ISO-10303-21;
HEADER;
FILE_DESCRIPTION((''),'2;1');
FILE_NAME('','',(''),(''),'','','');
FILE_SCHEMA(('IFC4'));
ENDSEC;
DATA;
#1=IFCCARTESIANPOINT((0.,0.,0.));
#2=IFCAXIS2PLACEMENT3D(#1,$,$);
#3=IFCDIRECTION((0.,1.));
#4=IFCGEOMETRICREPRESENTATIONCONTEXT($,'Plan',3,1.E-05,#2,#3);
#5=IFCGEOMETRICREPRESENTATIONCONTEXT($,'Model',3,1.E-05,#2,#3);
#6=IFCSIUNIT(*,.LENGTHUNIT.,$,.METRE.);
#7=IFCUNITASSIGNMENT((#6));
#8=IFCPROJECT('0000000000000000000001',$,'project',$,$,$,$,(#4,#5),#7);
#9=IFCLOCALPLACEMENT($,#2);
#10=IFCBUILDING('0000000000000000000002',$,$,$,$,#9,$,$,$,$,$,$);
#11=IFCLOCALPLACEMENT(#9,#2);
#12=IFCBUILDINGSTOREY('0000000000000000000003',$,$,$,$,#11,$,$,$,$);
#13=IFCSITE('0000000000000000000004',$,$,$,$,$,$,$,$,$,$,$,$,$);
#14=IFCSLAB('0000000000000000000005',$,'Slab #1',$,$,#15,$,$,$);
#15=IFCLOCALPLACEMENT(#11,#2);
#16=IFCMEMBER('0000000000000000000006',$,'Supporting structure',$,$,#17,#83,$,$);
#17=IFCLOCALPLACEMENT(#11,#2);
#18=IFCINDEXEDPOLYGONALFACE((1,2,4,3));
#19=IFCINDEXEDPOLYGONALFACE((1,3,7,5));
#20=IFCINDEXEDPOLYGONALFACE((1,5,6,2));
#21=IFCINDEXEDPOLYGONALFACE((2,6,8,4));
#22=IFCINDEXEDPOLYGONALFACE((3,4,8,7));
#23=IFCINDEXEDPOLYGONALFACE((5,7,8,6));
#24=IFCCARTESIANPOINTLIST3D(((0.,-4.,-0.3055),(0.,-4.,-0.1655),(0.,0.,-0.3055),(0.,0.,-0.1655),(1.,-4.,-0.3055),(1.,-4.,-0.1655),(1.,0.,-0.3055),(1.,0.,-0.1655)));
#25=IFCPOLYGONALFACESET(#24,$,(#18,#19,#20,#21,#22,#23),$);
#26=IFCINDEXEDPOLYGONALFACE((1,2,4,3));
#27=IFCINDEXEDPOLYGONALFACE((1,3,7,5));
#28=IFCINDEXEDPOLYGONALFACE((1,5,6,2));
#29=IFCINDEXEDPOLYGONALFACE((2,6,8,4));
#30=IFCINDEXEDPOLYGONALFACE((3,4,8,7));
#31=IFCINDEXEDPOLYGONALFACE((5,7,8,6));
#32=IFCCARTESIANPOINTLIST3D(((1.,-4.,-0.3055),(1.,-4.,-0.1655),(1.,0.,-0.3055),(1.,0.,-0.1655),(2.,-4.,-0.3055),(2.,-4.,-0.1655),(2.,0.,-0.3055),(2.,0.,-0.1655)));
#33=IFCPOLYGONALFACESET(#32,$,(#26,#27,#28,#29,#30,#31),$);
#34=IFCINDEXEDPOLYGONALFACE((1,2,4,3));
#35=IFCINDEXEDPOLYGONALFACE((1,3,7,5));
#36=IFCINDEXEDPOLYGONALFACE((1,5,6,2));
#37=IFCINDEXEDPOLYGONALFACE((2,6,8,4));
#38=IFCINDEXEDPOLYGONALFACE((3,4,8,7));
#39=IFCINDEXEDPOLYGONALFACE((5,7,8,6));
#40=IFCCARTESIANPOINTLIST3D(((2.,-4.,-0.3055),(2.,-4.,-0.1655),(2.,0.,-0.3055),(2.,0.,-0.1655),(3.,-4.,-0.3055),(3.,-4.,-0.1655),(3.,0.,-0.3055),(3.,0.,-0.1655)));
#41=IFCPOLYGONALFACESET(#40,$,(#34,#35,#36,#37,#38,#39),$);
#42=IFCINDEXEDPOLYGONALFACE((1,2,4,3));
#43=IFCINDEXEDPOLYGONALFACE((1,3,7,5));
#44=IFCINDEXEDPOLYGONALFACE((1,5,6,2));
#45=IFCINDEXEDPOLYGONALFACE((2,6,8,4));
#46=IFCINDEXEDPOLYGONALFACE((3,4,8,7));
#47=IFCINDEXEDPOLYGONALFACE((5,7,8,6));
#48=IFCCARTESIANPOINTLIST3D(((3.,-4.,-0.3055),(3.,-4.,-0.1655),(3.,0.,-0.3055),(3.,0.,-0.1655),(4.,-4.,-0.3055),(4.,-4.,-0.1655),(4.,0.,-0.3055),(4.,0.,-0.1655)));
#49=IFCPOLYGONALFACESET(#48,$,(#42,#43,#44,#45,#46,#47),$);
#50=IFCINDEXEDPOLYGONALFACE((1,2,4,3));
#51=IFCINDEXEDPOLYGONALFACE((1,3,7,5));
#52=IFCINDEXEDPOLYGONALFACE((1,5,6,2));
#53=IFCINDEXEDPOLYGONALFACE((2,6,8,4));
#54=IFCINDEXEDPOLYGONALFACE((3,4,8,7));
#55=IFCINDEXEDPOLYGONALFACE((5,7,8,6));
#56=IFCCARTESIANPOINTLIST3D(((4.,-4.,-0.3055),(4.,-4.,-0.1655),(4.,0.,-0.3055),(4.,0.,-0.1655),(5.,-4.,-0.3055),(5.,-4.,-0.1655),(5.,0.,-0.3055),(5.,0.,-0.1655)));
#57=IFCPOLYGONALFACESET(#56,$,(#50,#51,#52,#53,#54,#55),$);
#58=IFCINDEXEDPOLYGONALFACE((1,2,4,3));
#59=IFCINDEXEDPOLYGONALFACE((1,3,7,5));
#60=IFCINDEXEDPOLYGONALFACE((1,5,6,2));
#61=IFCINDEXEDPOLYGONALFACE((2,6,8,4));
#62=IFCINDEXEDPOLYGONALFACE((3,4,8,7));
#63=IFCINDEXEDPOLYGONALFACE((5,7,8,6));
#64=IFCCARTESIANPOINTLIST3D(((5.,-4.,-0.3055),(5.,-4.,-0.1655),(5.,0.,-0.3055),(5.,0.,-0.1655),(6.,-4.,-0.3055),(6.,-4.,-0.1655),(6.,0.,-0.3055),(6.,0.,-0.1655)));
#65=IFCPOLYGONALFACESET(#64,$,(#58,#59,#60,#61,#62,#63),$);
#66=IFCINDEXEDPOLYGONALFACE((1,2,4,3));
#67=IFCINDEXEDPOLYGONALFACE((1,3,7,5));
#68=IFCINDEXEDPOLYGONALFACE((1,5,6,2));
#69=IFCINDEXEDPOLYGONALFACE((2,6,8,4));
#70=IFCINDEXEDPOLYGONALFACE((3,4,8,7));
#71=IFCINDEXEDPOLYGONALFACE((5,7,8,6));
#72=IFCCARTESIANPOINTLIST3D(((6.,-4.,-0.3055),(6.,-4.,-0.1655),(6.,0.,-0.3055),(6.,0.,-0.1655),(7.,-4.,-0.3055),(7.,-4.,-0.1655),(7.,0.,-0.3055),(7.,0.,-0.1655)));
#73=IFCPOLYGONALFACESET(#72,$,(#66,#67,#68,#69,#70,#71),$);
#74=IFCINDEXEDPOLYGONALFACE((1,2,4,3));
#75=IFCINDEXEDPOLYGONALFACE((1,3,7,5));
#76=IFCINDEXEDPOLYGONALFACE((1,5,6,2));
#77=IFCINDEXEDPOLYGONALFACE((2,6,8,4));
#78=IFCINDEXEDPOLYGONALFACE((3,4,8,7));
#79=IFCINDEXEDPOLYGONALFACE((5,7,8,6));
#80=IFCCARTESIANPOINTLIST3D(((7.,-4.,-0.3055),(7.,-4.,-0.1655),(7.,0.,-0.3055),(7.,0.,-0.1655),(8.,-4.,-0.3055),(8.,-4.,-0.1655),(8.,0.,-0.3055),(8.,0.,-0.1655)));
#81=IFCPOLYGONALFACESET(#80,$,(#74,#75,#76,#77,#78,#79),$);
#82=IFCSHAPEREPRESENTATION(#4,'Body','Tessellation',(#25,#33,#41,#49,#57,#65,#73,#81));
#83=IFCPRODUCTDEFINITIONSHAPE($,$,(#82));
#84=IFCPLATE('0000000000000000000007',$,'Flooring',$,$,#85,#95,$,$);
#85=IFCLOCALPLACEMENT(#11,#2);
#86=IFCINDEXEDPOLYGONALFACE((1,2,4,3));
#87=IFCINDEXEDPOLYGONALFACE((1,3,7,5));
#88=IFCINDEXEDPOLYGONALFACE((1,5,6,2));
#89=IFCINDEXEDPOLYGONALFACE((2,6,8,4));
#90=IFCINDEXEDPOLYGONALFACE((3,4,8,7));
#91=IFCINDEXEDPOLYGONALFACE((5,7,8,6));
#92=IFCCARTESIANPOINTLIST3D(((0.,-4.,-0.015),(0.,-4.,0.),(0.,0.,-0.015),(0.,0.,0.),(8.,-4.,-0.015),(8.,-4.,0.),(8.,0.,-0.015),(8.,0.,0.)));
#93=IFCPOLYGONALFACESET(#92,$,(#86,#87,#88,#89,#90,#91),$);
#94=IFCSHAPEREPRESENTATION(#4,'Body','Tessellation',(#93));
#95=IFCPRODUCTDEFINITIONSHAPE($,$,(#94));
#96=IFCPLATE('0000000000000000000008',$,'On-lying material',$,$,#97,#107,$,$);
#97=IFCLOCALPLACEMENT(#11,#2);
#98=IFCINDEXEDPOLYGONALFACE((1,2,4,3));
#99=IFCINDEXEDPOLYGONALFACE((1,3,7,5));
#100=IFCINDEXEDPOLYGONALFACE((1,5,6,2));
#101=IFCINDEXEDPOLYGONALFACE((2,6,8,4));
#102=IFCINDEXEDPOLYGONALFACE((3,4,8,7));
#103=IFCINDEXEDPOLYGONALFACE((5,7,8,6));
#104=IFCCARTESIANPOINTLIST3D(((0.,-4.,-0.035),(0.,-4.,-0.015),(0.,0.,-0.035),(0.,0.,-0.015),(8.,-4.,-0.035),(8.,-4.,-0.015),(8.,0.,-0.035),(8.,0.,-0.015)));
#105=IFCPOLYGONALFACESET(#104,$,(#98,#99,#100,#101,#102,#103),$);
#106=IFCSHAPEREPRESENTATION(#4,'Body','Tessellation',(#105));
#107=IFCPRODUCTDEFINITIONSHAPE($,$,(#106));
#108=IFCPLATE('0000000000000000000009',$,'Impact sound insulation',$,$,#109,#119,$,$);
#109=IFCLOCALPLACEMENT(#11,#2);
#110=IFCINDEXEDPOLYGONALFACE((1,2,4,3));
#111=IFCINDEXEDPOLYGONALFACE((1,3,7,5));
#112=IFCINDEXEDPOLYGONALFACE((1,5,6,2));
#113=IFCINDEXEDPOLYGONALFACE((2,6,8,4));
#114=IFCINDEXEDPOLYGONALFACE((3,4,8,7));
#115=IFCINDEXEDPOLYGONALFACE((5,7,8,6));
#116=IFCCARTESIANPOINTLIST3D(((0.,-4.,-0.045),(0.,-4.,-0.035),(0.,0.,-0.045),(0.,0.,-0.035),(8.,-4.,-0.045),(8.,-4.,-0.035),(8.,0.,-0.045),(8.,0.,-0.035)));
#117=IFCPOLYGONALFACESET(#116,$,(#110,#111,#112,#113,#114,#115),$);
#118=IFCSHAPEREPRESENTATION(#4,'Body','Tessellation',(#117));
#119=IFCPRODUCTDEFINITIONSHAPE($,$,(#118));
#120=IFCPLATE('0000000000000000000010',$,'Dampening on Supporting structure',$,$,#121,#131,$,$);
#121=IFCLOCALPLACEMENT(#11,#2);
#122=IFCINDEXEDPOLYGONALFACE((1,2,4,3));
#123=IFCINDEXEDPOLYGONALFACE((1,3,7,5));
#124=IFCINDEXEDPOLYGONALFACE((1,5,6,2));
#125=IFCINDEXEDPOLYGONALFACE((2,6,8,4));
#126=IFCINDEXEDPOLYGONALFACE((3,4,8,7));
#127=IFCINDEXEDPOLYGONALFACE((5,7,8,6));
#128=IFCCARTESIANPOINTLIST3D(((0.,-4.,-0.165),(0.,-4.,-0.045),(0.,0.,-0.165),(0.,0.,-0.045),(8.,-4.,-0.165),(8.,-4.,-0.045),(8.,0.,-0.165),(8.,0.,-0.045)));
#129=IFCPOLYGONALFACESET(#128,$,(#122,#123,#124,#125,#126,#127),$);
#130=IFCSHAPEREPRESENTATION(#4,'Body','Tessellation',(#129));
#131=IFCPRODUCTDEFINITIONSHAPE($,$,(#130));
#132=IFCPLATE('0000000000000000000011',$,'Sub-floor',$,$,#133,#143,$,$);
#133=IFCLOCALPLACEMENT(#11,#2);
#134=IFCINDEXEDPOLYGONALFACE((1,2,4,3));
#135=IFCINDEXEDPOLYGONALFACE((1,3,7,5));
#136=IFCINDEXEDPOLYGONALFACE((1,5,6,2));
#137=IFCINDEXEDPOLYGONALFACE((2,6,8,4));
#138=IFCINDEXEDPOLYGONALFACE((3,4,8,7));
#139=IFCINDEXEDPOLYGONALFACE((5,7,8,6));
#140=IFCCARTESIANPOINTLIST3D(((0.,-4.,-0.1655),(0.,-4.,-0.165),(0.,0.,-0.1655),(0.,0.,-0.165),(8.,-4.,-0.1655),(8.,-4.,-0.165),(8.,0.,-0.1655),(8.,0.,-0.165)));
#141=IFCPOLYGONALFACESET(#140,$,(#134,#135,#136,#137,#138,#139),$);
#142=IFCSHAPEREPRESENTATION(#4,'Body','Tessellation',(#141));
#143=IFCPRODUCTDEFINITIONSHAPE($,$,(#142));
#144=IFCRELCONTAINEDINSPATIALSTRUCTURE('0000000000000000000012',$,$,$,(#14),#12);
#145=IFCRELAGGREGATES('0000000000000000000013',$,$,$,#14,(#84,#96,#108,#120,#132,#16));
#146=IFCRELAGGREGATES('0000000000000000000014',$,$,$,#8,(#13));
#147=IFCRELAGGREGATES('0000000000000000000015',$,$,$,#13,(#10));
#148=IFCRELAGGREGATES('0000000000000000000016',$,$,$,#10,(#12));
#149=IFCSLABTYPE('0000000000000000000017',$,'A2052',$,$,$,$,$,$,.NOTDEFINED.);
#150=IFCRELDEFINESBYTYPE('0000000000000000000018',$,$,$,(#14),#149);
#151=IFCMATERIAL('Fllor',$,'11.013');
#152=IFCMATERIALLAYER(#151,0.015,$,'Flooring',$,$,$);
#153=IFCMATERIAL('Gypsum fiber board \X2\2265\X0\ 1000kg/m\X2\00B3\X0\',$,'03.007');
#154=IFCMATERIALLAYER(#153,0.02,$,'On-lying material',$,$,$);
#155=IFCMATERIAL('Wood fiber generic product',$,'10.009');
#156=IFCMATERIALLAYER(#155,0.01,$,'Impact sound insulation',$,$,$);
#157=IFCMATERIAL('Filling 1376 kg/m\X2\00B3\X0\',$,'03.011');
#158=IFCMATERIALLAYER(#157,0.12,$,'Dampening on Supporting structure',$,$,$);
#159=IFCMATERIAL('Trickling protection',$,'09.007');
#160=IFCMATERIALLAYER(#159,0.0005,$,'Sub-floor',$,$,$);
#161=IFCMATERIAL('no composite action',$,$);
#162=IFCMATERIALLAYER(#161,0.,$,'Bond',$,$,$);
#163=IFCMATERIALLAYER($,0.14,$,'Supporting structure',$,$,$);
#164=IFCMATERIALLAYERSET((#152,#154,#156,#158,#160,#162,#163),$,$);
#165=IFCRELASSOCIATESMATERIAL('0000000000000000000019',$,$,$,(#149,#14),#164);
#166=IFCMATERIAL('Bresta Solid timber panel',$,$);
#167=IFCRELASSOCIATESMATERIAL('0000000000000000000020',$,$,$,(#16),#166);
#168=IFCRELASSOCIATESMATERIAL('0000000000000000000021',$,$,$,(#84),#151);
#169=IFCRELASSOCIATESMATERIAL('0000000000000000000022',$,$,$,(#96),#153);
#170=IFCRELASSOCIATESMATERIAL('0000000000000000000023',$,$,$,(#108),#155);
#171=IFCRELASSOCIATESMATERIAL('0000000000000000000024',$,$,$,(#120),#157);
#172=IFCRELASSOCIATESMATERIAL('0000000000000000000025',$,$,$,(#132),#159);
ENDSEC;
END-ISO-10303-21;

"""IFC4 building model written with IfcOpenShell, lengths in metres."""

from ifc_helpers import new_model, si_unit, direction, frame, frame_2d, origin, origin_with_axes, place, context, project, spatial, rectangle, extrude, material, layer, layer_set, type_object, element, aggregate, save


model = new_model("IFC4")

# Units and contexts
plan_context = context("Plan", 3, precision=1e-05, world=origin(), true_north=direction((0.0, 1.0)))
model_context = context("Model", 3, precision=1e-05, world=origin(), true_north=direction((0.0, 1.0)))
ifc_project = project(units=[si_unit("LENGTHUNIT", "METRE")], contexts=[plan_context, model_context])

# Site, building, storey
site = spatial("IfcSite", under=ifc_project)
building_placement = place(None, origin())
building = spatial("IfcBuilding", under=site, at=building_placement)
storey_placement = place(building_placement, origin())
storey = spatial("IfcBuildingStorey", under=building, at=storey_placement)

# Slab, member, plates
ifc_material_1 = material(Name="Fllor", Category="11.013")
ifc_layer_1 = layer(ifc_material_1, 0.015, Name="Flooring")
ifc_material_2 = material(Name="Gypsum fiber board ≥ 1000kg/m³", Category="03.007")
ifc_layer_2 = layer(ifc_material_2, 0.02, Name="On-lying material")
ifc_material_3 = material(Name="Wood fiber generic product", Category="10.009")
ifc_layer_3 = layer(ifc_material_3, 0.01, Name="Impact sound insulation")
ifc_material_4 = material(Name="Filling 1376 kg/m³", Category="03.011")
ifc_layer_4 = layer(ifc_material_4, 0.12, Name="Dampening on Supporting structure")
ifc_material_5 = material(Name="Trickling protection", Category="09.007")
ifc_layer_5 = layer(ifc_material_5, 0.0005, Name="Sub-floor")
ifc_material_6 = material(Name="no composite action")
ifc_layer_6 = layer(ifc_material_6, 0.0, Name="Bond")
ifc_layer_7 = layer(None, 0.14, Name="Supporting structure")
ifc_layer_set = layer_set([ifc_layer_1, ifc_layer_2, ifc_layer_3, ifc_layer_4, ifc_layer_5, ifc_layer_6, ifc_layer_7])
slab_type = type_object("IfcSlabType", Name="A2052", PredefinedType="NOTDEFINED", material=ifc_layer_set)
slab_placement = place(None, frame((0.0, 0.0, 0.0), z_axis=(0.0, 0.0, -1.0), x_axis=(1.0, 0.0, 0.0)))
slab = element("IfcSlab", 1, at=slab_placement, inside=storey, type_object=slab_type, material=ifc_layer_set, Name="Slab #1")
ifc_material_7 = material(Name="Bresta Solid timber panel")
member_placement = place(slab_placement, origin())
member = element("IfcMember", 2, at=member_placement, material=ifc_material_7, Name="Supporting structure", context=plan_context, shape_type="SweptSolid", body=[
    extrude(rectangle(XDim=1.0, YDim=0.14, at=frame_2d((0.5, 0.07), x_axis=(1.0, 0.0))), frame((0.0, 4.0, 0.1655), z_axis=(0.0, -1.0, 0.0), x_axis=(1.0, 0.0, 0.0)), (0.0, 0.0, 1.0), 4.0),
    extrude(rectangle(XDim=1.0, YDim=0.14, at=frame_2d((0.5, 0.07), x_axis=(1.0, 0.0))), frame((1.0, 4.0, 0.1655), z_axis=(0.0, -1.0, 0.0), x_axis=(1.0, 0.0, 0.0)), (0.0, 0.0, 1.0), 4.0),
    extrude(rectangle(XDim=1.0, YDim=0.14, at=frame_2d((0.5, 0.07), x_axis=(1.0, 0.0))), frame((2.0, 4.0, 0.1655), z_axis=(0.0, -1.0, 0.0), x_axis=(1.0, 0.0, 0.0)), (0.0, 0.0, 1.0), 4.0),
    extrude(rectangle(XDim=1.0, YDim=0.14, at=frame_2d((0.5, 0.07), x_axis=(1.0, 0.0))), frame((3.0, 4.0, 0.1655), z_axis=(0.0, -1.0, 0.0), x_axis=(1.0, 0.0, 0.0)), (0.0, 0.0, 1.0), 4.0),
    extrude(rectangle(XDim=1.0, YDim=0.14, at=frame_2d((0.5, 0.07), x_axis=(1.0, 0.0))), frame((4.0, 4.0, 0.1655), z_axis=(0.0, -1.0, 0.0), x_axis=(1.0, 0.0, 0.0)), (0.0, 0.0, 1.0), 4.0),
    extrude(rectangle(XDim=1.0, YDim=0.14, at=frame_2d((0.5, 0.07), x_axis=(1.0, 0.0))), frame((5.0, 4.0, 0.1655), z_axis=(0.0, -1.0, 0.0), x_axis=(1.0, 0.0, 0.0)), (0.0, 0.0, 1.0), 4.0),
    extrude(rectangle(XDim=1.0, YDim=0.14, at=frame_2d((0.5, 0.07), x_axis=(1.0, 0.0))), frame((6.0, 4.0, 0.1655), z_axis=(0.0, -1.0, 0.0), x_axis=(1.0, 0.0, 0.0)), (0.0, 0.0, 1.0), 4.0),
    extrude(rectangle(XDim=1.0, YDim=0.14, at=frame_2d((0.5, 0.07), x_axis=(1.0, 0.0))), frame((7.0, 4.0, 0.1655), z_axis=(0.0, -1.0, 0.0), x_axis=(1.0, 0.0, 0.0)), (0.0, 0.0, 1.0), 4.0),
])
plate_1_placement = place(slab_placement, origin())
plate_1 = element("IfcPlate", 3, at=plate_1_placement, material=ifc_material_1, Name="Flooring", context=plan_context, shape_type="SweptSolid", body=[
    extrude(rectangle(XDim=8.0, YDim=4.0, at=frame_2d((4.0, 2.0), x_axis=(1.0, 0.0))), origin_with_axes(), (0.0, 0.0, 1.0), 0.015),
])
plate_2_placement = place(slab_placement, origin())
plate_2 = element("IfcPlate", 4, at=plate_2_placement, material=ifc_material_2, Name="On-lying material", context=plan_context, shape_type="SweptSolid", body=[
    extrude(rectangle(XDim=8.0, YDim=4.0, at=frame_2d((4.0, 2.0), x_axis=(1.0, 0.0))), frame((0.0, 0.0, 0.015), z_axis=(0.0, 0.0, 1.0), x_axis=(1.0, 0.0, 0.0)), (0.0, 0.0, 1.0), 0.02),
])
plate_3_placement = place(slab_placement, origin())
plate_3 = element("IfcPlate", 5, at=plate_3_placement, material=ifc_material_3, Name="Impact sound insulation", context=plan_context, shape_type="SweptSolid", body=[
    extrude(rectangle(XDim=8.0, YDim=4.0, at=frame_2d((4.0, 2.0), x_axis=(1.0, 0.0))), frame((0.0, 0.0, 0.035), z_axis=(0.0, 0.0, 1.0), x_axis=(1.0, 0.0, 0.0)), (0.0, 0.0, 1.0), 0.01),
])
plate_4_placement = place(slab_placement, origin())
plate_4 = element("IfcPlate", 6, at=plate_4_placement, material=ifc_material_4, Name="Dampening on Supporting structure", context=plan_context, shape_type="SweptSolid", body=[
    extrude(rectangle(XDim=8.0, YDim=4.0, at=frame_2d((4.0, 2.0), x_axis=(1.0, 0.0))), frame((0.0, 0.0, 0.045), z_axis=(0.0, 0.0, 1.0), x_axis=(1.0, 0.0, 0.0)), (0.0, 0.0, 1.0), 0.12),
])
plate_5_placement = place(slab_placement, origin())
plate_5 = element("IfcPlate", 7, at=plate_5_placement, material=ifc_material_5, Name="Sub-floor", context=plan_context, shape_type="SweptSolid", body=[
    extrude(rectangle(XDim=8.0, YDim=4.0, at=frame_2d((4.0, 2.0), x_axis=(1.0, 0.0))), frame((0.0, 0.0, 0.165), z_axis=(0.0, 0.0, 1.0), x_axis=(1.0, 0.0, 0.0)), (0.0, 0.0, 1.0), 0.0005),
])
aggregate(slab, [plate_1, plate_2, plate_3, plate_4, plate_5, member])

save(model, "model.ifc")
